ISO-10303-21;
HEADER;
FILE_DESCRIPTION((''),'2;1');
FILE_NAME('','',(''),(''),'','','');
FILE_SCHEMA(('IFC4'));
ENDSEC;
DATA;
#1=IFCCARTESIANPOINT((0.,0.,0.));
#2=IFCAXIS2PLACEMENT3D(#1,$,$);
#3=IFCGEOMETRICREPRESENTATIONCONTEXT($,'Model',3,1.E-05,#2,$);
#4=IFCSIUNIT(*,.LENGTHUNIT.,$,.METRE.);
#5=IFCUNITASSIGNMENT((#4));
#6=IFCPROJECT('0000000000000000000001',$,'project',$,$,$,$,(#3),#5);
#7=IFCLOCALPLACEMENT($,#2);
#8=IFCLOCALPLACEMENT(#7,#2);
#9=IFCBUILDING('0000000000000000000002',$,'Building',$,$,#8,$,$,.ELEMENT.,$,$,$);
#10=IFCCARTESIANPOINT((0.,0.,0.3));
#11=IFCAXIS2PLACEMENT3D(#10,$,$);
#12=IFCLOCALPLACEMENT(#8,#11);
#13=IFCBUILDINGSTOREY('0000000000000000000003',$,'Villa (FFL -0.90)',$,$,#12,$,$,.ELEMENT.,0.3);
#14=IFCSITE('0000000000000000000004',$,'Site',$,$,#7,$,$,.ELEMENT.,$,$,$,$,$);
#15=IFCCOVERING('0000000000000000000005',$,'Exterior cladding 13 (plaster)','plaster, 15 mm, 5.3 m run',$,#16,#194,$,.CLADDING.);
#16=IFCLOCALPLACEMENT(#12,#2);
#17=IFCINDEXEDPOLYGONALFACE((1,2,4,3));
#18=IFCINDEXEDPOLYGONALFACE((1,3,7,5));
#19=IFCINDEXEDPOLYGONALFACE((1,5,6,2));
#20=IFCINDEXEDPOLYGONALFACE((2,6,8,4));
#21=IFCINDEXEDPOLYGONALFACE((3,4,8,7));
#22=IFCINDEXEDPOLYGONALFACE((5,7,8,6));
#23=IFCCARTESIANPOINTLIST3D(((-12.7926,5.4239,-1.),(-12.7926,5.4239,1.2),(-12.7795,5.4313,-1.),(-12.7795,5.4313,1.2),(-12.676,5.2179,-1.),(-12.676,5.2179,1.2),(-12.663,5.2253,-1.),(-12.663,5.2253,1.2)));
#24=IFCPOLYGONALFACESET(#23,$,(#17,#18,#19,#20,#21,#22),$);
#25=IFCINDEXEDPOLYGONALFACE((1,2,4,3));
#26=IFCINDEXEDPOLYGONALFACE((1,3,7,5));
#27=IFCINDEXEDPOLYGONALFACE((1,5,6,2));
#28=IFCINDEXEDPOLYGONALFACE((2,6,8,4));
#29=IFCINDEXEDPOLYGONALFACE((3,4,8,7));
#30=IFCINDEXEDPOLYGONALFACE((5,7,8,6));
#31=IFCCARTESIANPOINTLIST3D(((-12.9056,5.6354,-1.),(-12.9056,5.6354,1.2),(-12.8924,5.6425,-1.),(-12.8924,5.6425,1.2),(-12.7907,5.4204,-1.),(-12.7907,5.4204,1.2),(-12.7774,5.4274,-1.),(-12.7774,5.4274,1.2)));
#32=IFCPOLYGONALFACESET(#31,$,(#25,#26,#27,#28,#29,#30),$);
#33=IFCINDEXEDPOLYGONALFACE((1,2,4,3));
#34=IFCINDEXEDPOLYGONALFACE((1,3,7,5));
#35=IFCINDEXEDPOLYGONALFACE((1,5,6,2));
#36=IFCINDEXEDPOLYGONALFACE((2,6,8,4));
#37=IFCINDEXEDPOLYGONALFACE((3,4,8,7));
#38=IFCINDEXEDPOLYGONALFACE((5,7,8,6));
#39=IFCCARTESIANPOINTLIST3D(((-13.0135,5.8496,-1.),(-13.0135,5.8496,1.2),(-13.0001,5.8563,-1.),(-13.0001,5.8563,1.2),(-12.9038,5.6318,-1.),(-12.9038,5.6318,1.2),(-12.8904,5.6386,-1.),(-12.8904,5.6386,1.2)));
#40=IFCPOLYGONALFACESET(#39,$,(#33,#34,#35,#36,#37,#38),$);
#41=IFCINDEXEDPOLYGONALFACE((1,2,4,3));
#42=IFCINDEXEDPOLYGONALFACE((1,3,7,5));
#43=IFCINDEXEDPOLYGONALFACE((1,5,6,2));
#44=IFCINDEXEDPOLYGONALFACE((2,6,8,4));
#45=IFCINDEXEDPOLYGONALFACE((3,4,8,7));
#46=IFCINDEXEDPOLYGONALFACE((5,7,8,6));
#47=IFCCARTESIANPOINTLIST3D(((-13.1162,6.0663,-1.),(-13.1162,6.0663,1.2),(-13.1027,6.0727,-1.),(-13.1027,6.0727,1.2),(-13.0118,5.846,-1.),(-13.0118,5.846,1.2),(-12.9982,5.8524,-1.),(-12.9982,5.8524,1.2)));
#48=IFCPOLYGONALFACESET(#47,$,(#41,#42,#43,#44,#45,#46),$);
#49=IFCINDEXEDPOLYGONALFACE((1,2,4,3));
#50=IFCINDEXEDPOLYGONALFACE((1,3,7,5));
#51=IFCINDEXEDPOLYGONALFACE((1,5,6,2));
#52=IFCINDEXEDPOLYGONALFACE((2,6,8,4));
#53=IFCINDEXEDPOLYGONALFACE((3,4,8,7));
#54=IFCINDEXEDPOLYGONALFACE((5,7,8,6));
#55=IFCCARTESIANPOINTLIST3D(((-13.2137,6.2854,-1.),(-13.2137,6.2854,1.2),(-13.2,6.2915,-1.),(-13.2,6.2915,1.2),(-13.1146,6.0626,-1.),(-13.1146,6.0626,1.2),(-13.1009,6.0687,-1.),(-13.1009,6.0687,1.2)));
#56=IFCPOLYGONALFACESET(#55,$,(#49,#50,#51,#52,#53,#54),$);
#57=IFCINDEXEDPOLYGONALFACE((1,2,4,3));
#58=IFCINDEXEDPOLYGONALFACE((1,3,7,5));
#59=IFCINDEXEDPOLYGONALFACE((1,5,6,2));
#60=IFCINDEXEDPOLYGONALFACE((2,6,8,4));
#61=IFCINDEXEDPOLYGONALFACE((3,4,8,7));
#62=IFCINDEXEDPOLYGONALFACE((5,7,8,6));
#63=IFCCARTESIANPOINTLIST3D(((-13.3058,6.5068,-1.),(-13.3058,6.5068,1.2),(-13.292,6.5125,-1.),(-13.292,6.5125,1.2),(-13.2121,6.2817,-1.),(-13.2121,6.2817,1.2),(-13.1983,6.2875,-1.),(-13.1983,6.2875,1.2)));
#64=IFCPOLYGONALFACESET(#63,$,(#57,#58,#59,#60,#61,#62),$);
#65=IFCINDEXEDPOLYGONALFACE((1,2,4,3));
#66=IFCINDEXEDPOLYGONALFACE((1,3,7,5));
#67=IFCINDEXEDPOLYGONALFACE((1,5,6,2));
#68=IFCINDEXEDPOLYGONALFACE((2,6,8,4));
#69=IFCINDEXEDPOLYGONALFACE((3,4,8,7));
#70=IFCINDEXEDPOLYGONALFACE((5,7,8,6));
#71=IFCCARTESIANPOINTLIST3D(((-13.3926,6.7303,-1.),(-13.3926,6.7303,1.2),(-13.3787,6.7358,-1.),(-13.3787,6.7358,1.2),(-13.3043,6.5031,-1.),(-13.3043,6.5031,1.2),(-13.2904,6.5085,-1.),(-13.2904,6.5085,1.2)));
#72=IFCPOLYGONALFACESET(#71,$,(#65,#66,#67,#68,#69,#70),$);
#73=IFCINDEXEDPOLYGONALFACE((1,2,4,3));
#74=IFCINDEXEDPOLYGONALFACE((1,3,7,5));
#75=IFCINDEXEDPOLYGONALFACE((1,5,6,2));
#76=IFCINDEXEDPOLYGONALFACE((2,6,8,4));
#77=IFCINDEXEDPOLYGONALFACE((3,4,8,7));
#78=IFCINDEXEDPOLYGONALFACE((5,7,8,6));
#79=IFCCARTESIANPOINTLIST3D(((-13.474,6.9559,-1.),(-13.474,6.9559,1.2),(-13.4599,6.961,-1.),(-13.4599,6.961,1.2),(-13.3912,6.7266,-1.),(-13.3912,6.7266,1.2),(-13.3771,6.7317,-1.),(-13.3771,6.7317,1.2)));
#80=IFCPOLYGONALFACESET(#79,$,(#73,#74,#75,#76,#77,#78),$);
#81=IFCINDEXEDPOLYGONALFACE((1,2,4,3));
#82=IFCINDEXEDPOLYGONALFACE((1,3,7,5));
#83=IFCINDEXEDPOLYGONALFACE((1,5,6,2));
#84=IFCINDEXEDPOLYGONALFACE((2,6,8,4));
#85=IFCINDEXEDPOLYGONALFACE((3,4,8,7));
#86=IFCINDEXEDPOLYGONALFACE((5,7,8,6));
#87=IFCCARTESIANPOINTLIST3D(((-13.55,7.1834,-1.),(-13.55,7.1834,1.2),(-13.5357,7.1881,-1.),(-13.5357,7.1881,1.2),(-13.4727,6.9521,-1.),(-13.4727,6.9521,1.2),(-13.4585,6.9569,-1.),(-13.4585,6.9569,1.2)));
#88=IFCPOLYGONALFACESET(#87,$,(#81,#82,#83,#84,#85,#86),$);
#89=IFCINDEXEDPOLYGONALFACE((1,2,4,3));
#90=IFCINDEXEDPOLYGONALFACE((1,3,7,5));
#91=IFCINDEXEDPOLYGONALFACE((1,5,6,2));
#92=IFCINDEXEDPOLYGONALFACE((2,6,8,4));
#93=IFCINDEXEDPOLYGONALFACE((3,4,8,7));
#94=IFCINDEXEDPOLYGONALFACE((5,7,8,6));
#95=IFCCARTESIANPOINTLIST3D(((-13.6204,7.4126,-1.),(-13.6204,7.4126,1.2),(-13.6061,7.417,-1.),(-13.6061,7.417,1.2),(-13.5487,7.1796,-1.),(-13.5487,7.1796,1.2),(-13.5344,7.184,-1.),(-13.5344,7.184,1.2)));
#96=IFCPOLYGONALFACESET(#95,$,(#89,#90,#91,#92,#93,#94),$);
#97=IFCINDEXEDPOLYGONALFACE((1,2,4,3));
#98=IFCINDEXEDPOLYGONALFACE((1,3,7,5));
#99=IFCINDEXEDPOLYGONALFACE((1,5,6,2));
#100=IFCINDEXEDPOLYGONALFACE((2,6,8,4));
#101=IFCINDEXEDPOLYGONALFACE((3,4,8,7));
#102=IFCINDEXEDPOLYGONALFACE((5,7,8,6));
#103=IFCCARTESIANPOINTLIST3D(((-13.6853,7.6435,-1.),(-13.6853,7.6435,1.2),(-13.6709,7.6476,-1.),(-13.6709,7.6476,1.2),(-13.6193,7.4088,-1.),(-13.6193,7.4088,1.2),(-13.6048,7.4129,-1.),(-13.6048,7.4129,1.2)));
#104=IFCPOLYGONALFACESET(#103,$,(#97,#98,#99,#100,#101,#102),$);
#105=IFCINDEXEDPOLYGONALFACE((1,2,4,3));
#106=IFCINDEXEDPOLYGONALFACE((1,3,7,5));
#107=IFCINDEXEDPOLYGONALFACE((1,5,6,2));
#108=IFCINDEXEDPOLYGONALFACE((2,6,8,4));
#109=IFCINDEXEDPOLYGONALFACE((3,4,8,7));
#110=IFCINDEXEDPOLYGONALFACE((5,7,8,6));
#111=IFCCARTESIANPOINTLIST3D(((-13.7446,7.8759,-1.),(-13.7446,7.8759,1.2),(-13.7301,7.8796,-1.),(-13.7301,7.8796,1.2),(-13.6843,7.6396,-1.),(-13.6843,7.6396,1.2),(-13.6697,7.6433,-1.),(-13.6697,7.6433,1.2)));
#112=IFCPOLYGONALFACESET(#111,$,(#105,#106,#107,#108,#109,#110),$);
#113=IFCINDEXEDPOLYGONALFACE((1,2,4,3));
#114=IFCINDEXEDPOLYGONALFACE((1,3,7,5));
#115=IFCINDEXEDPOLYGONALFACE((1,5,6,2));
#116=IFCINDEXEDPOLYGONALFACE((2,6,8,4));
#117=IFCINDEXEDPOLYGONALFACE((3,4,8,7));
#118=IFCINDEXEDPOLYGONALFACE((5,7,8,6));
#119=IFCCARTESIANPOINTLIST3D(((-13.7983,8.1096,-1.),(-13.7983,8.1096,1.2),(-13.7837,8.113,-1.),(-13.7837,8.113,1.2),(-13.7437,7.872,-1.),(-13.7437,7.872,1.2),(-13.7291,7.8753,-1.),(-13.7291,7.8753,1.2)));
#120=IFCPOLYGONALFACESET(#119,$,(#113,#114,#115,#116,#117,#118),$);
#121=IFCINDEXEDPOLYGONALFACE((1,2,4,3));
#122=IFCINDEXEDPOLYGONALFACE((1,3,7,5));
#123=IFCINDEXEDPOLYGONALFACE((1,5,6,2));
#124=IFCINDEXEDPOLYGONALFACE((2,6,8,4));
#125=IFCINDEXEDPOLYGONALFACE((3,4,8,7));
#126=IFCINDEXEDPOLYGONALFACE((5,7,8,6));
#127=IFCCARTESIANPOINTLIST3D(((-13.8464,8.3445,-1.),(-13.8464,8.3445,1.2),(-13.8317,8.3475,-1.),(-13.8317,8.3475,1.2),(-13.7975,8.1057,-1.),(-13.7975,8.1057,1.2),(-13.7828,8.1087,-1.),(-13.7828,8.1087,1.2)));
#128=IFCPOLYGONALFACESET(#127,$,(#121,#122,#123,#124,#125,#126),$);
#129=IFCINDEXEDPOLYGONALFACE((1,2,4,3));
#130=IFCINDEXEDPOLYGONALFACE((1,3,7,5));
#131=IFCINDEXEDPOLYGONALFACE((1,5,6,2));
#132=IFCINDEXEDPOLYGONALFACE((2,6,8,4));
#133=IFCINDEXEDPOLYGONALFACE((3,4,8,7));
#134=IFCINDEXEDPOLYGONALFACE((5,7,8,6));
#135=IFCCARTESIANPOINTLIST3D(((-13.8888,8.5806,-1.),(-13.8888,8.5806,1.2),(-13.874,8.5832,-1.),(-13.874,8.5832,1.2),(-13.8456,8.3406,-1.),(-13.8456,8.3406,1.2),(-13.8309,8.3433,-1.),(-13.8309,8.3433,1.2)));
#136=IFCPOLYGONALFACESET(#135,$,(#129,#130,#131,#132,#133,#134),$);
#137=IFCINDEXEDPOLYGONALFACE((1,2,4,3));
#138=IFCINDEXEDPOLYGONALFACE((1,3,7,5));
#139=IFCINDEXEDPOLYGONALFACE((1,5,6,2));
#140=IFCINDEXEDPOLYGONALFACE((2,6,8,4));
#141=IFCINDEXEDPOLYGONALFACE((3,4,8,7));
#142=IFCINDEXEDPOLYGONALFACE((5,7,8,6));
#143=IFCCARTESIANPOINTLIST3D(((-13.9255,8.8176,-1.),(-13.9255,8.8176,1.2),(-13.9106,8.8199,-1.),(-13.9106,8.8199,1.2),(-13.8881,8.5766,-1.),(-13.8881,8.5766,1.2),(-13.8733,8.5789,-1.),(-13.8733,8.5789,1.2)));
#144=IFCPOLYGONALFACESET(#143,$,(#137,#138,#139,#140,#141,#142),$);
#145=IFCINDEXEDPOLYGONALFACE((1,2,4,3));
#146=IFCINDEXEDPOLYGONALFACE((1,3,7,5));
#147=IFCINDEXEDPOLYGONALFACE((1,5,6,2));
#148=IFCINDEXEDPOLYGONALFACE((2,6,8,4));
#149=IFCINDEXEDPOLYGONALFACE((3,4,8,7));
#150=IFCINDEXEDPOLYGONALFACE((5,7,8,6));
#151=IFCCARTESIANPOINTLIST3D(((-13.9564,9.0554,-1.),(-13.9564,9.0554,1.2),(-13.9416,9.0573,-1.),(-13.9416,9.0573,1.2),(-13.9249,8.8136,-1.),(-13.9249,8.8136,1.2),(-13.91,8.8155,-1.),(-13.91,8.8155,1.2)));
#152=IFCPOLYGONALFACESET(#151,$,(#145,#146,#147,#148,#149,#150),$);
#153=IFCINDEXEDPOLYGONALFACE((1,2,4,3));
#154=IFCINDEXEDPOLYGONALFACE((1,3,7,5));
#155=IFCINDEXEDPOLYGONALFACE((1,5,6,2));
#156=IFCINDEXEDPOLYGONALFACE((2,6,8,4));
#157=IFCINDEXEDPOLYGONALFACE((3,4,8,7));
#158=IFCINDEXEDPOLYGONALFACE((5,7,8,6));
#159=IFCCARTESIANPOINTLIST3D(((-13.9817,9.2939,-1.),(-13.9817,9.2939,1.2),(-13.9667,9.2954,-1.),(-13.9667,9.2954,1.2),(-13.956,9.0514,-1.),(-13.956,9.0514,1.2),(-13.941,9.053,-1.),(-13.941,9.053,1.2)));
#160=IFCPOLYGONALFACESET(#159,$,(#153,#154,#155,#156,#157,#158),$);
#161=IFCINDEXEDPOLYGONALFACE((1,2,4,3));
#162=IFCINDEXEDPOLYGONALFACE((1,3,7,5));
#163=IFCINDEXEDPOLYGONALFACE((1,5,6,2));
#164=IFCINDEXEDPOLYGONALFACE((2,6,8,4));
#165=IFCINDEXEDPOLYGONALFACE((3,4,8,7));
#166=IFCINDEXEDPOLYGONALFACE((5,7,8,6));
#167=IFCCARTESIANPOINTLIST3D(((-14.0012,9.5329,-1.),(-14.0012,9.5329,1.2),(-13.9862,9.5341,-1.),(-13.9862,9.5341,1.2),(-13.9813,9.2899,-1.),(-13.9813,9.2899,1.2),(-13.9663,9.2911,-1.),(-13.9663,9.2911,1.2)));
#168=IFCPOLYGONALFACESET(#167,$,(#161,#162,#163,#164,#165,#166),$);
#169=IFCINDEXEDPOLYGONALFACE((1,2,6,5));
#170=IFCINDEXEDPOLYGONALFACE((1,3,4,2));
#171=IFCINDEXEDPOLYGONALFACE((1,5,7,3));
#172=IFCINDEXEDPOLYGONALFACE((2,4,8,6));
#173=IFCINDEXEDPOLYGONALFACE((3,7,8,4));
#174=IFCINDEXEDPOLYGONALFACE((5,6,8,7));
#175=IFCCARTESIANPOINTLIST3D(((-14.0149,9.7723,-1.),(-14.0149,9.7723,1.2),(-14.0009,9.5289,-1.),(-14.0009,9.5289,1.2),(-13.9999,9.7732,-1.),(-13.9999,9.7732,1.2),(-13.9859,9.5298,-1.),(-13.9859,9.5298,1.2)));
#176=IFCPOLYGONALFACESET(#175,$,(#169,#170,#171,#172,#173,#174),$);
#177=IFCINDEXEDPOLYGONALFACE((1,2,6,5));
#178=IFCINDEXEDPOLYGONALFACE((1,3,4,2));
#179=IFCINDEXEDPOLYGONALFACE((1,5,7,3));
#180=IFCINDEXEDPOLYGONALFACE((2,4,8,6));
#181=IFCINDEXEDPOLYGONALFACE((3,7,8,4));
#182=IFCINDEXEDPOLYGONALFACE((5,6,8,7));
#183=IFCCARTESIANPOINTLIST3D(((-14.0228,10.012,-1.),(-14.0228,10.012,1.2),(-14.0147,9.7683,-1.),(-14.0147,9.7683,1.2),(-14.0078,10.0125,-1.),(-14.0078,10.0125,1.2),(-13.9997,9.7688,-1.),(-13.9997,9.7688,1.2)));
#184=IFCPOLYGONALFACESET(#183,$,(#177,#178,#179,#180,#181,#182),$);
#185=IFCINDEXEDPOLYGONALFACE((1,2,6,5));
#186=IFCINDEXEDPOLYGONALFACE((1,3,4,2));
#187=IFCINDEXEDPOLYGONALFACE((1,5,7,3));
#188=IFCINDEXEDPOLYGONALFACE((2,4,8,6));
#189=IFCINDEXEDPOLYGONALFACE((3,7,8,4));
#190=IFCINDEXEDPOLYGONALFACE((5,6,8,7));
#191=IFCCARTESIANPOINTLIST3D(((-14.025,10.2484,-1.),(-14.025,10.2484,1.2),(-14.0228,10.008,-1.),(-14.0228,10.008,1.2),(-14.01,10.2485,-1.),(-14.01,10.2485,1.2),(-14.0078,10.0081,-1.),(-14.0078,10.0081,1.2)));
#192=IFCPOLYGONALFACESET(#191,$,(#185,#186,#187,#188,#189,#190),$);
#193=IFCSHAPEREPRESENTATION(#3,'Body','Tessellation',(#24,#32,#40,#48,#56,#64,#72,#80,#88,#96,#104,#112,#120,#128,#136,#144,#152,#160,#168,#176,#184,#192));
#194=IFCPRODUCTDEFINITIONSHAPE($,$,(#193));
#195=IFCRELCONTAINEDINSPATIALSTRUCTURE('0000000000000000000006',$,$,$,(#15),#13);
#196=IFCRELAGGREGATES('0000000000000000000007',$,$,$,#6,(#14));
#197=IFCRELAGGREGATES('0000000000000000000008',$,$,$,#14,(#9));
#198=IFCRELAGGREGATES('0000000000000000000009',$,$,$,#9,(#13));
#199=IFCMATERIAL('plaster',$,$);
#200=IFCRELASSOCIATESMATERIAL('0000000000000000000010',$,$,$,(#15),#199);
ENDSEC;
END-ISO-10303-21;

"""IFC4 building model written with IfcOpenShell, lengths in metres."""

from ifc_helpers import new_model, si_unit, frame, origin, origin_with_axes, place, context, project, spatial, polyline, outline, extrude, material, element, save


model = new_model("IFC4")

# Units and contexts
model_context = context("Model", 3, precision=1e-05, world=origin())
ifc_project = project(units=[si_unit("LENGTHUNIT", "METRE")], contexts=[model_context])

# Site, building, storey
site_placement = place(None, origin())
site = spatial("IfcSite", under=ifc_project, at=site_placement, Name="Site", CompositionType="ELEMENT")
building_placement = place(site_placement, origin())
building = spatial("IfcBuilding", under=site, at=building_placement, Name="Building", CompositionType="ELEMENT")
storey_placement = place(building_placement, frame((0.0, 0.0, 0.3)))
storey = spatial("IfcBuildingStorey", under=building, at=storey_placement, Name="Villa (FFL -0.90)", CompositionType="ELEMENT", Elevation=0.3)

# Covering
ifc_material = material(Name="plaster")
covering_1_placement = place(storey_placement, origin_with_axes())
element("IfcCovering", 1, at=covering_1_placement, inside=storey, material=ifc_material, Name="Exterior cladding 13 (plaster)", Description="plaster, 15 mm, 5.3 m run", PredefinedType="CLADDING", context=model_context, shape_type="SweptSolid", body=[
    extrude(outline(polyline([(-12.663, 5.2253), (-12.7795, 5.4313), (-12.7926, 5.4239), (-12.676, 5.2179), (-12.663, 5.2253)])), frame((0.0, 0.0, -1.0)), (0.0, 0.0, 1.0), 2.2),
    extrude(outline(polyline([(-12.7774, 5.4274), (-12.8924, 5.6425), (-12.9056, 5.6354), (-12.7907, 5.4204), (-12.7774, 5.4274)])), frame((0.0, 0.0, -1.0)), (0.0, 0.0, 1.0), 2.2),
    extrude(outline(polyline([(-12.8904, 5.6386), (-13.0001, 5.8563), (-13.0135, 5.8496), (-12.9038, 5.6318), (-12.8904, 5.6386)])), frame((0.0, 0.0, -1.0)), (0.0, 0.0, 1.0), 2.2),
    extrude(outline(polyline([(-12.9982, 5.8524), (-13.1027, 6.0727), (-13.1162, 6.0663), (-13.0118, 5.846), (-12.9982, 5.8524)])), frame((0.0, 0.0, -1.0)), (0.0, 0.0, 1.0), 2.2),
    extrude(outline(polyline([(-13.1009, 6.0687), (-13.2, 6.2915), (-13.2137, 6.2854), (-13.1146, 6.0626), (-13.1009, 6.0687)])), frame((0.0, 0.0, -1.0)), (0.0, 0.0, 1.0), 2.2),
    extrude(outline(polyline([(-13.1983, 6.2875), (-13.292, 6.5125), (-13.3058, 6.5068), (-13.2121, 6.2817), (-13.1983, 6.2875)])), frame((0.0, 0.0, -1.0)), (0.0, 0.0, 1.0), 2.2),
    extrude(outline(polyline([(-13.2904, 6.5085), (-13.3787, 6.7358), (-13.3926, 6.7303), (-13.3043, 6.5031), (-13.2904, 6.5085)])), frame((0.0, 0.0, -1.0)), (0.0, 0.0, 1.0), 2.2),
    extrude(outline(polyline([(-13.3771, 6.7317), (-13.4599, 6.961), (-13.474, 6.9559), (-13.3912, 6.7266), (-13.3771, 6.7317)])), frame((0.0, 0.0, -1.0)), (0.0, 0.0, 1.0), 2.2),
    extrude(outline(polyline([(-13.4585, 6.9569), (-13.5357, 7.1881), (-13.55, 7.1834), (-13.4727, 6.9521), (-13.4585, 6.9569)])), frame((0.0, 0.0, -1.0)), (0.0, 0.0, 1.0), 2.2),
    extrude(outline(polyline([(-13.5344, 7.184), (-13.6061, 7.417), (-13.6204, 7.4126), (-13.5487, 7.1796), (-13.5344, 7.184)])), frame((0.0, 0.0, -1.0)), (0.0, 0.0, 1.0), 2.2),
    extrude(outline(polyline([(-13.6048, 7.4129), (-13.6709, 7.6476), (-13.6853, 7.6435), (-13.6193, 7.4088), (-13.6048, 7.4129)])), frame((0.0, 0.0, -1.0)), (0.0, 0.0, 1.0), 2.2),
    extrude(outline(polyline([(-13.6697, 7.6433), (-13.7301, 7.8796), (-13.7446, 7.8759), (-13.6843, 7.6396), (-13.6697, 7.6433)])), frame((0.0, 0.0, -1.0)), (0.0, 0.0, 1.0), 2.2),
    extrude(outline(polyline([(-13.7291, 7.8753), (-13.7837, 8.113), (-13.7983, 8.1096), (-13.7437, 7.872), (-13.7291, 7.8753)])), frame((0.0, 0.0, -1.0)), (0.0, 0.0, 1.0), 2.2),
    extrude(outline(polyline([(-13.7828, 8.1087), (-13.8317, 8.3475), (-13.8464, 8.3445), (-13.7975, 8.1057), (-13.7828, 8.1087)])), frame((0.0, 0.0, -1.0)), (0.0, 0.0, 1.0), 2.2),
    extrude(outline(polyline([(-13.8309, 8.3433), (-13.874, 8.5832), (-13.8888, 8.5806), (-13.8456, 8.3406), (-13.8309, 8.3433)])), frame((0.0, 0.0, -1.0)), (0.0, 0.0, 1.0), 2.2),
    extrude(outline(polyline([(-13.8733, 8.5789), (-13.9106, 8.8199), (-13.9255, 8.8176), (-13.8881, 8.5766), (-13.8733, 8.5789)])), frame((0.0, 0.0, -1.0)), (0.0, 0.0, 1.0), 2.2),
    extrude(outline(polyline([(-13.91, 8.8155), (-13.9416, 9.0573), (-13.9564, 9.0554), (-13.9249, 8.8136), (-13.91, 8.8155)])), frame((0.0, 0.0, -1.0)), (0.0, 0.0, 1.0), 2.2),
    extrude(outline(polyline([(-13.941, 9.053), (-13.9667, 9.2954), (-13.9817, 9.2939), (-13.956, 9.0514), (-13.941, 9.053)])), frame((0.0, 0.0, -1.0)), (0.0, 0.0, 1.0), 2.2),
    extrude(outline(polyline([(-13.9663, 9.2911), (-13.9862, 9.5341), (-14.0012, 9.5329), (-13.9813, 9.2899), (-13.9663, 9.2911)])), frame((0.0, 0.0, -1.0)), (0.0, 0.0, 1.0), 2.2),
    extrude(outline(polyline([(-13.9859, 9.5298), (-13.9999, 9.7732), (-14.0149, 9.7723), (-14.0009, 9.5289), (-13.9859, 9.5298)])), frame((0.0, 0.0, -1.0)), (0.0, 0.0, 1.0), 2.2),
    extrude(outline(polyline([(-13.9997, 9.7688), (-14.0078, 10.0125), (-14.0228, 10.012), (-14.0147, 9.7683), (-13.9997, 9.7688)])), frame((0.0, 0.0, -1.0)), (0.0, 0.0, 1.0), 2.2),
    extrude(outline(polyline([(-14.0078, 10.0081), (-14.01, 10.2485), (-14.025, 10.2484), (-14.0228, 10.008), (-14.0078, 10.0081)])), frame((0.0, 0.0, -1.0)), (0.0, 0.0, 1.0), 2.2),
])

save(model, "model.ifc")
